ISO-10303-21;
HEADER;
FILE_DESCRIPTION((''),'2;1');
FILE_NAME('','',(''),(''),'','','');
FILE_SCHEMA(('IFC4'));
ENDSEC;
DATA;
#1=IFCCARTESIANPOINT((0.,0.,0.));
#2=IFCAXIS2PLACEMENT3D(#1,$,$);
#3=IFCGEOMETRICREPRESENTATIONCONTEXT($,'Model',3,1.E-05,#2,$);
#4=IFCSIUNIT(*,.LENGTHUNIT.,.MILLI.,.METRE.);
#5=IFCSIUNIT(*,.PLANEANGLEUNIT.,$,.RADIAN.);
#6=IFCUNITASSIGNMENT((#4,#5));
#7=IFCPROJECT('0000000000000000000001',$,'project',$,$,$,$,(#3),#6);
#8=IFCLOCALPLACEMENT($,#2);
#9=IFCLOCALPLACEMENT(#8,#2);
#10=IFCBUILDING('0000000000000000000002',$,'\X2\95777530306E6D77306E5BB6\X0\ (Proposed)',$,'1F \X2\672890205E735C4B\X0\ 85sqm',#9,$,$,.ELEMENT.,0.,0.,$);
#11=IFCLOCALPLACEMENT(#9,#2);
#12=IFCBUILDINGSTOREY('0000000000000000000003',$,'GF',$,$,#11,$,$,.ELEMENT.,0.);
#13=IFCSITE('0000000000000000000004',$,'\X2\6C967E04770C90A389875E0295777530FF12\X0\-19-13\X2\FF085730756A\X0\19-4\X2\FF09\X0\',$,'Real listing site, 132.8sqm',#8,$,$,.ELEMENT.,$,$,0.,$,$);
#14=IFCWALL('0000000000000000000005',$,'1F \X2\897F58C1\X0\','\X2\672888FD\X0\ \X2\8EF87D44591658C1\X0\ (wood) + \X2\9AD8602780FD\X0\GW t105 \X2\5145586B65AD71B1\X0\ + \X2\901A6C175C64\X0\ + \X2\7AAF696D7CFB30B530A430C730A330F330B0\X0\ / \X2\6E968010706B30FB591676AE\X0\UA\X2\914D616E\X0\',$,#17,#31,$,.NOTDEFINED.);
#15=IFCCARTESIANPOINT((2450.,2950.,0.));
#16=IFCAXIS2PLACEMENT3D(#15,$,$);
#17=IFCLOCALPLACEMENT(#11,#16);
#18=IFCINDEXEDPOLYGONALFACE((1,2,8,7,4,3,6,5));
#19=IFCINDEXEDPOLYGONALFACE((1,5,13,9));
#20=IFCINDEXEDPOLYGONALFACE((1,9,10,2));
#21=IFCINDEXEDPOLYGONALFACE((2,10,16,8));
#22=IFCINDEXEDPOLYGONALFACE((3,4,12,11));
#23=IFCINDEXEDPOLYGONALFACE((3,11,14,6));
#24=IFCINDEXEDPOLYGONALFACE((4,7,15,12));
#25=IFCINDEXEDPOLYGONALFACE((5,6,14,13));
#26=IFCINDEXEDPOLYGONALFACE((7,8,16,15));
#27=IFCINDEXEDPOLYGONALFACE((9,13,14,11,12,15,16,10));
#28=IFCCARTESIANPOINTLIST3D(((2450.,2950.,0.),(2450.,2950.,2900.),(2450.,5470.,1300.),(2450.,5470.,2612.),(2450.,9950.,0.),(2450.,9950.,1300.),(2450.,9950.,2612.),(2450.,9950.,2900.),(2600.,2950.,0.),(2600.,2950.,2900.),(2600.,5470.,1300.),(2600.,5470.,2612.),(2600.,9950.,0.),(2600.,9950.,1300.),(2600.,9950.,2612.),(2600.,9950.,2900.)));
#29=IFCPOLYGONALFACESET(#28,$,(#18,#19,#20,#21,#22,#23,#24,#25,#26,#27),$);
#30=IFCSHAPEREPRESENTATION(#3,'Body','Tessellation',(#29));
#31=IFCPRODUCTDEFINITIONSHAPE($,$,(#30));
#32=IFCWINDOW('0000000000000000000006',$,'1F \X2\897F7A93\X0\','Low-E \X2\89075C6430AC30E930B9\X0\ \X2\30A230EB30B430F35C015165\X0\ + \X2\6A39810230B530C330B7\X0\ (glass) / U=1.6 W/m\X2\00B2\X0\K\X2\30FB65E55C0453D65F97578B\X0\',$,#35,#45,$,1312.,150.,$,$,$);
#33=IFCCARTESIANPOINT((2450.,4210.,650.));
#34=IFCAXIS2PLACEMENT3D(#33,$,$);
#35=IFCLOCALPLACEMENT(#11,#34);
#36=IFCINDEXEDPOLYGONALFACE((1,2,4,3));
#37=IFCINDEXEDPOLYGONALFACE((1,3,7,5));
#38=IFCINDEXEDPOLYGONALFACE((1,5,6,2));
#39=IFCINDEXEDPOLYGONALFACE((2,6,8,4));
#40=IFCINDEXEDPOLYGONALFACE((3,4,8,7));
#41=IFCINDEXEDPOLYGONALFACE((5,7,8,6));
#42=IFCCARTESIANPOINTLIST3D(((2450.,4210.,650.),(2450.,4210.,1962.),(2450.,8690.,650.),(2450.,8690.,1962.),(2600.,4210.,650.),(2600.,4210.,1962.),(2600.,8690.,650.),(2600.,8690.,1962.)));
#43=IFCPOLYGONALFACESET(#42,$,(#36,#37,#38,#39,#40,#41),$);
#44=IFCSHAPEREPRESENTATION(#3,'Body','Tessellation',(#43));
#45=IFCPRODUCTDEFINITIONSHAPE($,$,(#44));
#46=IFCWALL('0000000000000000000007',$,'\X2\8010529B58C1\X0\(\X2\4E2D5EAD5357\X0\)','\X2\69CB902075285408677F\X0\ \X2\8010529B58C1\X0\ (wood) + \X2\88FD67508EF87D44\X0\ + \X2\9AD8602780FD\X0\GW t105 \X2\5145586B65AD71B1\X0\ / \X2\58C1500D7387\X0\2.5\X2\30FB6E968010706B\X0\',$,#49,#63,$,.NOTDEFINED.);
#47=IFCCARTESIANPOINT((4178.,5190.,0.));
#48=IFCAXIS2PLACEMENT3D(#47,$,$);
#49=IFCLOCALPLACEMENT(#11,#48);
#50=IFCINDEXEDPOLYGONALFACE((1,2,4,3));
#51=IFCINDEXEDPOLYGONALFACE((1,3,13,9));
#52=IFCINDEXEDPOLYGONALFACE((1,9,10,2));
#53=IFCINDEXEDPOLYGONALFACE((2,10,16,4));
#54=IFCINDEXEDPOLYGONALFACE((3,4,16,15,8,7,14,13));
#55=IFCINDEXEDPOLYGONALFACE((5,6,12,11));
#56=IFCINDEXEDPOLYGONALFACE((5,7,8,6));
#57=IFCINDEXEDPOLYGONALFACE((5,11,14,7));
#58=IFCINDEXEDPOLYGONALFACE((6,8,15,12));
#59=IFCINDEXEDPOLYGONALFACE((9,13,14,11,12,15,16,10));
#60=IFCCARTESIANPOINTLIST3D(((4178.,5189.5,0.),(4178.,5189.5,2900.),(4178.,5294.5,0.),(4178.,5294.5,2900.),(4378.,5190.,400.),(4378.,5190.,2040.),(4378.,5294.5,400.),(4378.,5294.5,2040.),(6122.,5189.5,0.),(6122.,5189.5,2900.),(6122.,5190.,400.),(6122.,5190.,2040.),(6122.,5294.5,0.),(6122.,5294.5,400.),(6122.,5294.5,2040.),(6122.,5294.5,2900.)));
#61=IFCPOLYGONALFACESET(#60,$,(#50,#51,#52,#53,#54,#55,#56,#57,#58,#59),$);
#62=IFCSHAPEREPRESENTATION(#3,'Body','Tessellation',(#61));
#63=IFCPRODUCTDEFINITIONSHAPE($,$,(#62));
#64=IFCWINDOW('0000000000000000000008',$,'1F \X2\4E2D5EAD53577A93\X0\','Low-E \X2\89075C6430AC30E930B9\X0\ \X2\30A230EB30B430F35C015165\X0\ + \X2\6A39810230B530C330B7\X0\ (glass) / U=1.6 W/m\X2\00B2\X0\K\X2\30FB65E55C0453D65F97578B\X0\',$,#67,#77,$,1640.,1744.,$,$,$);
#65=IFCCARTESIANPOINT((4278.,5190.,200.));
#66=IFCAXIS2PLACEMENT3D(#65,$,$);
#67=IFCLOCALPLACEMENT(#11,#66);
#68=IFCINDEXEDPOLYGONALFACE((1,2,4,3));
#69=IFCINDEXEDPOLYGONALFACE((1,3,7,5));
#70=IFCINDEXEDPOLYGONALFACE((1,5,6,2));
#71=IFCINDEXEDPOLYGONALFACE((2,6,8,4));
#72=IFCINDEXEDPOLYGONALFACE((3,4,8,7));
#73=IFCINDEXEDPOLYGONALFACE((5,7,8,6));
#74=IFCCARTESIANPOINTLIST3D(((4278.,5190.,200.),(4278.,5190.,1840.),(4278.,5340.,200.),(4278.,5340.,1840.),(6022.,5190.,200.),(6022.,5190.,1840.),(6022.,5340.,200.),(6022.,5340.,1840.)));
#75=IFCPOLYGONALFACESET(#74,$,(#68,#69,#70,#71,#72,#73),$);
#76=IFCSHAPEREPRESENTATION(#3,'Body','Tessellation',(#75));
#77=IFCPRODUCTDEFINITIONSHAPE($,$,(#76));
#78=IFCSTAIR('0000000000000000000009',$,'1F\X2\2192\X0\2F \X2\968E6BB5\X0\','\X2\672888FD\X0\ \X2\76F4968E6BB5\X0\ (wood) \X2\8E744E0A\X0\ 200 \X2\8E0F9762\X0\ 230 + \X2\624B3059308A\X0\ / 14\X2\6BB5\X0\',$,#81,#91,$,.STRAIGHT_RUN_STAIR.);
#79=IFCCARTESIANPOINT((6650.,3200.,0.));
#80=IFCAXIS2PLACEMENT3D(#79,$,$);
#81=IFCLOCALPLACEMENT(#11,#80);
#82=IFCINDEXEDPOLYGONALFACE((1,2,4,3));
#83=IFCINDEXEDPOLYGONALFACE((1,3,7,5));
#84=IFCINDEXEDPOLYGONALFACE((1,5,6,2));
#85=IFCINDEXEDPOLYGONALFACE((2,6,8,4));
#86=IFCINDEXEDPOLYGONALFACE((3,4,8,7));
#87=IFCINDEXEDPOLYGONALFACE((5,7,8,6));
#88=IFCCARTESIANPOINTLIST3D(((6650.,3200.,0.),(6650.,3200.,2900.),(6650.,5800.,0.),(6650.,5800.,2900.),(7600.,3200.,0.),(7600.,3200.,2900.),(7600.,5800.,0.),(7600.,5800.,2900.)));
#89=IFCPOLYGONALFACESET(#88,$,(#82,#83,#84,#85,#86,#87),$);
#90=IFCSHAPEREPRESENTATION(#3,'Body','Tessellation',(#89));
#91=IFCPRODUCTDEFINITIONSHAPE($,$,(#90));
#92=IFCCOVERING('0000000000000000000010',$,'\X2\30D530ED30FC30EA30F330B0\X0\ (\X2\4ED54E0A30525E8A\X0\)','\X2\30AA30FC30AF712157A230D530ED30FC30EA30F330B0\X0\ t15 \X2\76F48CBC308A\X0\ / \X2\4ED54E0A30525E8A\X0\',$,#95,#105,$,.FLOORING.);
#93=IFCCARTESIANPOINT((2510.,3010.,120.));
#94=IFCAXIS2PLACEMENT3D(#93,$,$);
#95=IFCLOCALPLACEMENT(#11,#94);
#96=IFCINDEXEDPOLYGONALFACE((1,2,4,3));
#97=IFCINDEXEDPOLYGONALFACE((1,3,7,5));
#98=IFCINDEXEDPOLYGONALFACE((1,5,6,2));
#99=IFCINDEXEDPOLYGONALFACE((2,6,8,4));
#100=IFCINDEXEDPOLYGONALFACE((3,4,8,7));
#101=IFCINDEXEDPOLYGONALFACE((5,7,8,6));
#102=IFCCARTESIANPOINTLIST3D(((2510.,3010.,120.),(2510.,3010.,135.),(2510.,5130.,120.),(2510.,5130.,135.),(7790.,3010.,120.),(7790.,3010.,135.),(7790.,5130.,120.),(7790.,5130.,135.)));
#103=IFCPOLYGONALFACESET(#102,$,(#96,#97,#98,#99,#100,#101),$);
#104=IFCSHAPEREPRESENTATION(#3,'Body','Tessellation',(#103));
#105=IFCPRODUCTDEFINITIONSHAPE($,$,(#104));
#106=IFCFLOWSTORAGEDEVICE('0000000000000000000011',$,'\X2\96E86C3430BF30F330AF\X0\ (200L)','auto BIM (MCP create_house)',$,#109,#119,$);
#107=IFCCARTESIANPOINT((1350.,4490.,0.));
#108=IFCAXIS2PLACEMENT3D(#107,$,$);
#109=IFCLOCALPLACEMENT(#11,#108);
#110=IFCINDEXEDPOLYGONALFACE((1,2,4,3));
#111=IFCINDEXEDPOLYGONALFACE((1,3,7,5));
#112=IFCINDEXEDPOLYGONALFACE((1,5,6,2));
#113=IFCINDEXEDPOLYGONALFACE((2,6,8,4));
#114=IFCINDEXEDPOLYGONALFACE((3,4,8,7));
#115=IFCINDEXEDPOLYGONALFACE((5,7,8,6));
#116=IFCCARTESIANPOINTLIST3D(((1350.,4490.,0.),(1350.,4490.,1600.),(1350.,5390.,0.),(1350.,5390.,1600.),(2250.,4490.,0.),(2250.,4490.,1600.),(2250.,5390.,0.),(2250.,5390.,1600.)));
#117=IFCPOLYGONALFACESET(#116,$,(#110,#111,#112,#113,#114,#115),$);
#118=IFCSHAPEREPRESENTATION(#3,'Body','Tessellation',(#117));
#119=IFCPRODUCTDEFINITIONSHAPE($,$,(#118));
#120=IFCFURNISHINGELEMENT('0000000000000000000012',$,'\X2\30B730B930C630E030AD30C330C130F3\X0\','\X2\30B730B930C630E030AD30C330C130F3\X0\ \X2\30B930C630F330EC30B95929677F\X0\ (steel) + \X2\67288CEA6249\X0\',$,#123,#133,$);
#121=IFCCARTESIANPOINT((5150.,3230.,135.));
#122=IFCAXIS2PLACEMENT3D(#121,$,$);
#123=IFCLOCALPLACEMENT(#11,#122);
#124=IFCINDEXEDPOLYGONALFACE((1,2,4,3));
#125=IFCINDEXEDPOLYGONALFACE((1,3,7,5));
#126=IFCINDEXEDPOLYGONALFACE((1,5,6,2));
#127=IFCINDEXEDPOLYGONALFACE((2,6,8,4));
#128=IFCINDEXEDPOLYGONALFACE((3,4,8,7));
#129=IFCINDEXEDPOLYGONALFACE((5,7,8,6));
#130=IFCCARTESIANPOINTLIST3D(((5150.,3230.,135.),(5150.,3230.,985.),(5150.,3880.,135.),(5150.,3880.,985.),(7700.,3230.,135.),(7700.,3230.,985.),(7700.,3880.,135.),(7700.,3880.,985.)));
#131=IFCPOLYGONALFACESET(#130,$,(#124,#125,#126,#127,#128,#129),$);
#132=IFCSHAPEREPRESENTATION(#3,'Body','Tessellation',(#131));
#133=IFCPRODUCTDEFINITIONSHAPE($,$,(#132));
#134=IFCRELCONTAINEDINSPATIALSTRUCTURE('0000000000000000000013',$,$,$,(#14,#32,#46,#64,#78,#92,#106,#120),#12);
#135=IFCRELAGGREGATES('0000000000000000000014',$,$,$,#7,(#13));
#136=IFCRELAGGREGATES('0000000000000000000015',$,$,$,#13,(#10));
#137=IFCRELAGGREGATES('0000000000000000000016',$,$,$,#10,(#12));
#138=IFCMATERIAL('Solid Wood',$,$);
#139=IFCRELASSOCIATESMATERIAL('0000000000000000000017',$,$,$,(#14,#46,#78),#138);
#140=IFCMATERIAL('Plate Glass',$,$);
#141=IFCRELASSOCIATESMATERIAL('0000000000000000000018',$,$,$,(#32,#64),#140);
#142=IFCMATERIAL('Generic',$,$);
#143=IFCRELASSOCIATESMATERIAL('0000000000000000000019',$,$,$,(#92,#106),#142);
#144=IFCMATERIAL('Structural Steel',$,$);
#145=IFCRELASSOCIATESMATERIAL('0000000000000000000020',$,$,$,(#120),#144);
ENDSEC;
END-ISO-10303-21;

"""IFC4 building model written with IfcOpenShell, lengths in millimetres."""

from ifc_helpers import new_model, si_unit, frame, frame_2d, origin, place, context, project, spatial, rectangle, extrude, material, element, fill, save


model = new_model("IFC4")

# Units and contexts
model_context = context("Model", 3, precision=1e-05, world=origin())
ifc_project = project(units=[si_unit("LENGTHUNIT", "METRE", prefix="MILLI"), si_unit("PLANEANGLEUNIT", "RADIAN")], contexts=[model_context])

# Site, building, storey
site_placement = place(None, origin())
site = spatial("IfcSite", under=ifc_project, at=site_placement, Name="沖縄県那覇市長田２-19-13（地番19-4）", ObjectType="Real listing site, 132.8sqm", CompositionType="ELEMENT", RefElevation=0.0)
building_placement = place(site_placement, origin())
building = spatial("IfcBuilding", under=site, at=building_placement, Name="長田の海の家 (Proposed)", ObjectType="1F 木造平屋 85sqm", CompositionType="ELEMENT", ElevationOfRefHeight=0.0, ElevationOfTerrain=0.0)
storey_placement = place(building_placement, origin())
storey = spatial("IfcBuildingStorey", under=building, at=storey_placement, Name="GF", CompositionType="ELEMENT", Elevation=0.0)

# Shared definitions
ifc_material_1 = material(Name="Solid Wood")
ifc_material_2 = material(Name="Generic")

# Shared definitions
ifc_material_3 = material(Name="Plate Glass")

# Walls, openings, windows
wall_1_placement = place(storey_placement, frame((2450.0, 2950.0, 0.0)))
wall_1 = element("IfcWall", 1, at=wall_1_placement, inside=storey, material=ifc_material_1, Name="1F 西壁", Description="木製 軸組外壁 (wood) + 高性能GW t105 充填断熱 + 通気層 + 窯業系サイディング / 準耐火・外皮UA配慮", PredefinedType="NOTDEFINED", context=model_context, shape_type="SweptSolid", body=[
    extrude(rectangle(XDim=150.0, YDim=7000.0, at=frame_2d((75.0, 3500.0))), frame((2450.0, 2950.0, 0.0)), (0.0, 0.0, 1.0), 2900.0),
])
opening_1_placement = place(storey_placement, frame((2450.0, 4210.0, 650.0)))
opening_1 = element("IfcOpeningElement", 2, at=opening_1_placement, cuts=wall_1, PredefinedType="NOTDEFINED", context=model_context, shape_type="SweptSolid", body=[
    extrude(rectangle(XDim=150.0, YDim=4480.0, at=frame_2d((75.0, 2240.0))), frame((2450.0, 4210.0, 650.0)), (0.0, 0.0, 1.0), 1312.0),
])
window_1_placement = place(storey_placement, frame((2450.0, 4210.0, 650.0)))
window_1 = element("IfcWindow", 3, at=window_1_placement, inside=storey, material=ifc_material_3, Name="1F 西窓", Description="Low-E 複層ガラス アルゴン封入 + 樹脂サッシ (glass) / U=1.6 W/m²K・日射取得型", OverallHeight=1312.0, OverallWidth=150.0, context=model_context, shape_type="SweptSolid", body=[
    extrude(rectangle(XDim=150.0, YDim=4480.0, at=frame_2d((75.0, 2240.0))), frame((2450.0, 4210.0, 650.0)), (0.0, 0.0, 1.0), 1312.0),
])
fill(opening_1, window_1)
wall_2_placement = place(storey_placement, frame((4178.0, 5190.0, 0.0)))
wall_2 = element("IfcWall", 4, at=wall_2_placement, inside=storey, material=ifc_material_1, Name="耐力壁(中庭南)", Description="構造用合板 耐力壁 (wood) + 製材軸組 + 高性能GW t105 充填断熱 / 壁倍率2.5・準耐火", PredefinedType="NOTDEFINED", context=model_context, shape_type="SweptSolid", body=[
    extrude(rectangle(XDim=1944.0, YDim=105.0, at=frame_2d((972.0, 52.0))), frame((4178.0, 5190.0, 0.0)), (0.0, 0.0, 1.0), 2900.0),
])
opening_2_placement = place(storey_placement, frame((4278.0, 5190.0, 200.0)))
opening_2 = element("IfcOpeningElement", 5, at=opening_2_placement, cuts=wall_2, PredefinedType="NOTDEFINED", context=model_context, shape_type="SweptSolid", body=[
    extrude(rectangle(XDim=1744.0, YDim=150.0, at=frame_2d((872.0, 75.0))), frame((4278.0, 5190.0, 200.0)), (0.0, 0.0, 1.0), 1640.0),
])
window_2_placement = place(storey_placement, frame((4278.0, 5190.0, 200.0)))
window_2 = element("IfcWindow", 6, at=window_2_placement, inside=storey, material=ifc_material_3, Name="1F 中庭南窓", Description="Low-E 複層ガラス アルゴン封入 + 樹脂サッシ (glass) / U=1.6 W/m²K・日射取得型", OverallHeight=1640.0, OverallWidth=1744.0, context=model_context, shape_type="SweptSolid", body=[
    extrude(rectangle(XDim=1744.0, YDim=150.0, at=frame_2d((872.0, 75.0))), frame((4278.0, 5190.0, 200.0)), (0.0, 0.0, 1.0), 1640.0),
])
fill(opening_2, window_2)

# Stair
stair_placement = place(storey_placement, frame((6650.0, 3200.0, 0.0)))
element("IfcStair", 7, at=stair_placement, inside=storey, material=ifc_material_1, Name="1F→2F 階段", Description="木製 直階段 (wood) 蹴上 200 踏面 230 + 手すり / 14段", PredefinedType="STRAIGHT_RUN_STAIR", context=model_context, shape_type="SweptSolid", body=[
    extrude(rectangle(XDim=950.0, YDim=2600.0, at=frame_2d((475.0, 1300.0))), frame((6650.0, 3200.0, 0.0)), (0.0, 0.0, 1.0), 2900.0),
])

# Covering
covering_placement = place(storey_placement, frame((2510.0, 3010.0, 120.0)))
element("IfcCovering", 8, at=covering_placement, inside=storey, material=ifc_material_2, Name="フローリング (仕上げ床)", Description="オーク無垢フローリング t15 直貼り / 仕上げ床", PredefinedType="FLOORING", context=model_context, shape_type="SweptSolid", body=[
    extrude(rectangle(XDim=5280.0, YDim=2120.0, at=frame_2d((2640.0, 1060.0))), frame((2510.0, 3010.0, 120.0)), (0.0, 0.0, 1.0), 15.0),
])

# Flow storage device
flow_storage_device_placement = place(storey_placement, frame((1350.0, 4490.0, 0.0)))
element("IfcFlowStorageDevice", 9, at=flow_storage_device_placement, inside=storey, material=ifc_material_2, Name="雨水タンク (200L)", Description="auto BIM (MCP create_house)", context=model_context, shape_type="SweptSolid", body=[
    extrude(rectangle(XDim=900.0, YDim=900.0, at=frame_2d((450.0, 450.0))), frame((1350.0, 4490.0, 0.0)), (0.0, 0.0, 1.0), 1600.0),
])

# Furnishing element
ifc_material_4 = material(Name="Structural Steel")
furnishing_placement = place(storey_placement, frame((5150.0, 3230.0, 135.0)))
element("IfcFurnishingElement", 10, at=furnishing_placement, inside=storey, material=ifc_material_4, Name="システムキッチン", Description="システムキッチン ステンレス天板 (steel) + 木質扉", context=model_context, shape_type="SweptSolid", body=[
    extrude(rectangle(XDim=2550.0, YDim=650.0, at=frame_2d((1275.0, 325.0))), frame((5150.0, 3230.0, 135.0)), (0.0, 0.0, 1.0), 850.0),
])

save(model, "model.ifc")
